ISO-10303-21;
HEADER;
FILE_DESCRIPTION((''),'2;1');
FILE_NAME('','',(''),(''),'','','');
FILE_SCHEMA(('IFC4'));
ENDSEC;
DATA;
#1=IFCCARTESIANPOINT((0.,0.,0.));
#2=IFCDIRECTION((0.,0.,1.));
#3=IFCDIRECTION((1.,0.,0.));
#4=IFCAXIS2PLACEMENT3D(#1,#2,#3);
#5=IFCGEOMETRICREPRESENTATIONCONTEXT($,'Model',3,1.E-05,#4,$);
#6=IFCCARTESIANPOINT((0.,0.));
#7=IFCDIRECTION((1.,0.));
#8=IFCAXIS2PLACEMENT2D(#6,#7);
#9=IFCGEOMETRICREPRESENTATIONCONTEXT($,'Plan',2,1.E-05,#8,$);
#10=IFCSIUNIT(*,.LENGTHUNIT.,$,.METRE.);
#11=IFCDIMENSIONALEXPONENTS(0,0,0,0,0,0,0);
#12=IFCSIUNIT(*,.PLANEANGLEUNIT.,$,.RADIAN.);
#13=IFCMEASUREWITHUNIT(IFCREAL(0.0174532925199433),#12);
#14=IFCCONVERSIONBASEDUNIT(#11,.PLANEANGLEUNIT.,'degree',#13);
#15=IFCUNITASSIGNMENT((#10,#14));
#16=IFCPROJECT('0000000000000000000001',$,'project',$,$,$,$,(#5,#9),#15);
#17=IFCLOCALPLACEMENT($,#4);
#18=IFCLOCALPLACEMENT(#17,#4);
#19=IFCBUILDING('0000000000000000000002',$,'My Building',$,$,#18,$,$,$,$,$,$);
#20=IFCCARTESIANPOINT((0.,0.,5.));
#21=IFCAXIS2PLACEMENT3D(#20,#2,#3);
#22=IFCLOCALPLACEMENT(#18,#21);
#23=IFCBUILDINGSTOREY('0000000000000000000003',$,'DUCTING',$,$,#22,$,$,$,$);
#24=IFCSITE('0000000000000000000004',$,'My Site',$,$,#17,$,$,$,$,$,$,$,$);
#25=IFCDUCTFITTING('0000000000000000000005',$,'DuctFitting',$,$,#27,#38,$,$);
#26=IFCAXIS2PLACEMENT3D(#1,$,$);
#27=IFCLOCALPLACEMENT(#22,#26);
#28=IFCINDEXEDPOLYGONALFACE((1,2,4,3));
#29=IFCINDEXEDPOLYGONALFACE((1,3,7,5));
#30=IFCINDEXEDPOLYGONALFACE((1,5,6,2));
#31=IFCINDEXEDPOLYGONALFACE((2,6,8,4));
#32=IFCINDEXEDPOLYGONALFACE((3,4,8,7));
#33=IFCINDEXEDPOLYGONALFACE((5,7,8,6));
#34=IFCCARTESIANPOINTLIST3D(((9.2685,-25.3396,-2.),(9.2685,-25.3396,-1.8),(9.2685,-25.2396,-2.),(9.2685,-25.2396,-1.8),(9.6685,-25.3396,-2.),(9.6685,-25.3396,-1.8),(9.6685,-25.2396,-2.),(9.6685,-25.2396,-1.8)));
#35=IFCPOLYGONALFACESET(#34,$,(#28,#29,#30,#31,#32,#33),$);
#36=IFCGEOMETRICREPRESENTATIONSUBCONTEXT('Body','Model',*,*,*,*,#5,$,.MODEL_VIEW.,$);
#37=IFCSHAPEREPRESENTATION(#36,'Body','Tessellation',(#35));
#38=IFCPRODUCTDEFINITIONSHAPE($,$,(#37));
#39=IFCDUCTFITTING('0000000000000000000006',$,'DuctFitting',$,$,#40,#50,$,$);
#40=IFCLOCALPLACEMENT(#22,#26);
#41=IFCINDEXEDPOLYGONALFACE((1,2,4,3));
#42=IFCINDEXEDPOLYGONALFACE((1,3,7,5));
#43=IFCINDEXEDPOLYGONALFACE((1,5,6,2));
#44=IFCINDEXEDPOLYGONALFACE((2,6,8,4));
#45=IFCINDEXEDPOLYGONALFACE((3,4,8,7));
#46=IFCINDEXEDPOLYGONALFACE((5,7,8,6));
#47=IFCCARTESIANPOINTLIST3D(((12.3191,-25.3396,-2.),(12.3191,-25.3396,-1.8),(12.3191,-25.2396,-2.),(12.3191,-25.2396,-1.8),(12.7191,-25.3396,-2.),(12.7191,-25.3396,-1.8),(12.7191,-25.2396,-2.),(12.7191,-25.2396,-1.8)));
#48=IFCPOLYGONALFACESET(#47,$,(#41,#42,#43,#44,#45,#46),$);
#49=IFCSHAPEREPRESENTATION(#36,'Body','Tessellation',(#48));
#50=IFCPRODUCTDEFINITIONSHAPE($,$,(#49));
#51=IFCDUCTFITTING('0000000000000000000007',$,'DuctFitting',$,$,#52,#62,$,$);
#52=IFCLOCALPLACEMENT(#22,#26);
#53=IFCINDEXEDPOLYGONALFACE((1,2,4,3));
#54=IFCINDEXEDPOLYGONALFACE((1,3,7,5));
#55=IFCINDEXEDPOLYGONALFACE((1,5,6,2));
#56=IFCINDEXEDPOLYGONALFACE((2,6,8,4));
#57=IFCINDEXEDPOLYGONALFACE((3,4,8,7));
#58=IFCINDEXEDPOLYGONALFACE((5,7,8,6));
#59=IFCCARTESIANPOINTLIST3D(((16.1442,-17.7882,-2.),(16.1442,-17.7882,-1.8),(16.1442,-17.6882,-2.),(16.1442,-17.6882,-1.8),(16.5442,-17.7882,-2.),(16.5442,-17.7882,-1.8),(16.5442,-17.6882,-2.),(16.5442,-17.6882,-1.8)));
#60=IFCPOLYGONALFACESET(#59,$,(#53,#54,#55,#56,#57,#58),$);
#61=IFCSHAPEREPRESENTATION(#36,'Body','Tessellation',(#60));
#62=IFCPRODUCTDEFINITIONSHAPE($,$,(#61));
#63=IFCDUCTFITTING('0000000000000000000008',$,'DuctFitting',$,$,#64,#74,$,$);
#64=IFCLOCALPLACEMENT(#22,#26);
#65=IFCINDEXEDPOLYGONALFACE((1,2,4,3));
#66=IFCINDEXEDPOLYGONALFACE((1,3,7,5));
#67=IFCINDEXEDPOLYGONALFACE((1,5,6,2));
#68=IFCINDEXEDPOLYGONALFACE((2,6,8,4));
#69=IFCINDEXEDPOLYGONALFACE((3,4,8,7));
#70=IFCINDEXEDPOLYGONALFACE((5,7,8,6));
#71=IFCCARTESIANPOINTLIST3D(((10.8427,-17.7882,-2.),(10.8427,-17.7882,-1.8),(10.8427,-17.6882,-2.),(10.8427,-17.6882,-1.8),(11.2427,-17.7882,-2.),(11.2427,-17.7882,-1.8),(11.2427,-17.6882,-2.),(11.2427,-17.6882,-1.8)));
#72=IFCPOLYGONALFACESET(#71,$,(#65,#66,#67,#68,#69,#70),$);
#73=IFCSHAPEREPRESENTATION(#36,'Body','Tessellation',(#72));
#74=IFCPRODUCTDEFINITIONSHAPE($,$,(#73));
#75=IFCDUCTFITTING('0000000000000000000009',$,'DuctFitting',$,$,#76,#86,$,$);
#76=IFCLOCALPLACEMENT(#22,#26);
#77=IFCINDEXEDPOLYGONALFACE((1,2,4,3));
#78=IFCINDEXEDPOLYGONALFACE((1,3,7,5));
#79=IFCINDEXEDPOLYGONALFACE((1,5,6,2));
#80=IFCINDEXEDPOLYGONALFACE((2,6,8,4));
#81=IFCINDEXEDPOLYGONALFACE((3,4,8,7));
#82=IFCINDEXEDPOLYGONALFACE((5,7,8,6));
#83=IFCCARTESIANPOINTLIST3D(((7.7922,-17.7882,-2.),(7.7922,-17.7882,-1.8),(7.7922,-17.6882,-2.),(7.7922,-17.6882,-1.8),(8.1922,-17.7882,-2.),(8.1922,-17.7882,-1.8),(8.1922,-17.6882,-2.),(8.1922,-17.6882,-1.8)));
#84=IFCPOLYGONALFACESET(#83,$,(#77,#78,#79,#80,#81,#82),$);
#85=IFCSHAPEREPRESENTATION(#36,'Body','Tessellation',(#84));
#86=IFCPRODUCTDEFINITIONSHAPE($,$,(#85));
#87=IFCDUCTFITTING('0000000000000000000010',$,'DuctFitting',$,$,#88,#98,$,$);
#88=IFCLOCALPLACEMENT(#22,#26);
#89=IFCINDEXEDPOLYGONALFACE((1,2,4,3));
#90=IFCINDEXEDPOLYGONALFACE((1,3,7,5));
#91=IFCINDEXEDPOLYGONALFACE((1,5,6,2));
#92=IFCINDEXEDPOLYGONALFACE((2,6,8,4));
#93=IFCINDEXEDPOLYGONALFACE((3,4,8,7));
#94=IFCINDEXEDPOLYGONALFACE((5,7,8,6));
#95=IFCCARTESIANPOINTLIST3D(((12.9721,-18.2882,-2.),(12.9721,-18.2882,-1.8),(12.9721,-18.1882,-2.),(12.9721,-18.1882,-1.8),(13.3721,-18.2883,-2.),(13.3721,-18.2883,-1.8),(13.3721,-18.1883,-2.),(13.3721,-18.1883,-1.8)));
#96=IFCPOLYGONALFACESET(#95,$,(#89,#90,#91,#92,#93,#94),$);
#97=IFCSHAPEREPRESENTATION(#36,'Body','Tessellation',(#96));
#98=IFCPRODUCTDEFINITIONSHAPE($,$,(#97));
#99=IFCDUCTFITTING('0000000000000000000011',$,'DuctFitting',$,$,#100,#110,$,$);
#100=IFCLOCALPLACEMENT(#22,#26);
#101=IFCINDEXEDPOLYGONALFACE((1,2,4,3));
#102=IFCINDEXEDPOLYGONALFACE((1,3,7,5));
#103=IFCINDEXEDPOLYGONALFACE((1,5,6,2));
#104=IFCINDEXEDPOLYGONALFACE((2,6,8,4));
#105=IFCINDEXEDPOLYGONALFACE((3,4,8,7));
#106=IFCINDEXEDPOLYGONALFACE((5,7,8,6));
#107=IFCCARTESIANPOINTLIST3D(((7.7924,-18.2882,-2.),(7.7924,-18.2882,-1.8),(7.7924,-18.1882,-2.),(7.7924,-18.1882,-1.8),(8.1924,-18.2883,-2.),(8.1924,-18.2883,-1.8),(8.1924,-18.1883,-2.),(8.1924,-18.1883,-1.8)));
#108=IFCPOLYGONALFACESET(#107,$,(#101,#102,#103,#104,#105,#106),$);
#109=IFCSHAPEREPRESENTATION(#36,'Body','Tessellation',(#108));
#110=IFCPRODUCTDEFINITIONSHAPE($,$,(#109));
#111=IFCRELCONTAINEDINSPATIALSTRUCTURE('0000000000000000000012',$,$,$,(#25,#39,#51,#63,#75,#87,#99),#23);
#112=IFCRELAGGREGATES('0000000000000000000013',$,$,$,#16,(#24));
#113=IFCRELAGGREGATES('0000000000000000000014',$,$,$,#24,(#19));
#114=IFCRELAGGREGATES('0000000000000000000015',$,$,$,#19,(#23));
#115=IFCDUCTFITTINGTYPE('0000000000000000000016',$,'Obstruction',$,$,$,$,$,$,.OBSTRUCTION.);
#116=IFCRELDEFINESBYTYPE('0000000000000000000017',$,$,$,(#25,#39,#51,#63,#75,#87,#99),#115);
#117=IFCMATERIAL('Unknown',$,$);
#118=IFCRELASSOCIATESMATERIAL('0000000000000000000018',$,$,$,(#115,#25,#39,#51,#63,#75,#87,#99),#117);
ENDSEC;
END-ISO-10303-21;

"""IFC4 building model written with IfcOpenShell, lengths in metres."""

from ifc_helpers import new_model, entity, si_unit, converted_unit, frame, origin_with_axes, origin_2d_with_axis, place, context, subcontext, project, spatial, rectangle, extrude, material, material_profile, profile_set, profile_usage, type_object, element, save


model = new_model("IFC4")

# Units and contexts
model_context = context("Model", 3, precision=1e-05, world=origin_with_axes())
plan_context = context("Plan", 2, precision=1e-05, world=origin_2d_with_axis())
body_context = subcontext(model_context, "Body", "Model", "MODEL_VIEW")
ifc_project = project(units=[si_unit("LENGTHUNIT", "METRE"), converted_unit("PLANEANGLEUNIT", "degree", entity("IfcReal", 0.0174532925199433), si_unit("PLANEANGLEUNIT", "RADIAN"), dimensions=[0, 0, 0, 0, 0, 0, 0])], contexts=[model_context, plan_context])

# Site, building, storey
site_placement = place(None, origin_with_axes())
site = spatial("IfcSite", under=ifc_project, at=site_placement, Name="My Site")
building_placement = place(site_placement, origin_with_axes())
building = spatial("IfcBuilding", under=site, at=building_placement, Name="My Building")
storey_placement = place(building_placement, frame((0.0, 0.0, 5.0), z_axis=(0.0, 0.0, 1.0), x_axis=(1.0, 0.0, 0.0)))
storey = spatial("IfcBuildingStorey", under=building, at=storey_placement, Name="DUCTING")

# Shared definitions
ifc_material = material(Name="Unknown")

# Duct fittings
ifc_material_profile_1 = material_profile(ifc_material, rectangle(XDim=0.4, YDim=0.2))
ifc_profile_set_1 = profile_set([ifc_material_profile_1])
duct_fitting_type = type_object("IfcDuctFittingType", Name="Obstruction", PredefinedType="OBSTRUCTION", material=ifc_profile_set_1)
ifc_profile_usage_1 = profile_usage(ifc_profile_set_1, cardinal=5)
duct_fitting_1_placement = place(storey_placement, frame((9.4685, -25.3396, -1.9), z_axis=(0.000001, 1.0, 0.000001), x_axis=(-1.0, 0.000001, 0.0)))
element("IfcDuctFitting", 1, at=duct_fitting_1_placement, inside=storey, type_object=duct_fitting_type, material=ifc_profile_usage_1, Name="DuctFitting", context=body_context, shape_type="SweptSolid", body=[
    extrude(rectangle(XDim=0.4, YDim=0.2), origin_with_axes(), (0.0, 0.0, 1.0), 0.1),
])
ifc_profile_usage_2 = profile_usage(ifc_profile_set_1, cardinal=5)
duct_fitting_2_placement = place(storey_placement, frame((12.5191, -25.3396, -1.9), z_axis=(0.000001, 1.0, 0.000001), x_axis=(-1.0, 0.000001, 0.0)))
element("IfcDuctFitting", 2, at=duct_fitting_2_placement, inside=storey, type_object=duct_fitting_type, material=ifc_profile_usage_2, Name="DuctFitting", context=body_context, shape_type="SweptSolid", body=[
    extrude(rectangle(XDim=0.4, YDim=0.2), origin_with_axes(), (0.0, 0.0, 1.0), 0.1),
])
ifc_profile_usage_3 = profile_usage(ifc_profile_set_1, cardinal=5)
duct_fitting_3_placement = place(storey_placement, frame((16.3442, -17.7882, -1.9), z_axis=(0.0, 1.0, 0.0), x_axis=(-1.0, 0.0, 0.0)))
element("IfcDuctFitting", 3, at=duct_fitting_3_placement, inside=storey, type_object=duct_fitting_type, material=ifc_profile_usage_3, Name="DuctFitting", context=body_context, shape_type="SweptSolid", body=[
    extrude(rectangle(XDim=0.4, YDim=0.2), origin_with_axes(), (0.0, 0.0, 1.0), 0.1),
])
ifc_profile_usage_4 = profile_usage(ifc_profile_set_1, cardinal=5)
duct_fitting_4_placement = place(storey_placement, frame((11.0427, -17.7882, -1.9), z_axis=(0.0, 1.0, 0.0), x_axis=(-1.0, 0.0, 0.0)))
element("IfcDuctFitting", 4, at=duct_fitting_4_placement, inside=storey, type_object=duct_fitting_type, material=ifc_profile_usage_4, Name="DuctFitting", context=body_context, shape_type="SweptSolid", body=[
    extrude(rectangle(XDim=0.4, YDim=0.2), origin_with_axes(), (0.0, 0.0, 1.0), 0.1),
])
ifc_profile_usage_5 = profile_usage(ifc_profile_set_1, cardinal=5)
duct_fitting_5_placement = place(storey_placement, frame((7.9922, -17.7882, -1.9), z_axis=(0.0, 1.0, 0.0), x_axis=(-1.0, 0.0, 0.0)))
element("IfcDuctFitting", 5, at=duct_fitting_5_placement, inside=storey, type_object=duct_fitting_type, material=ifc_profile_usage_5, Name="DuctFitting", context=body_context, shape_type="SweptSolid", body=[
    extrude(rectangle(XDim=0.4, YDim=0.2), origin_with_axes(), (0.0, 0.0, 1.0), 0.1),
])
ifc_profile_usage_6 = profile_usage(ifc_profile_set_1, cardinal=5)
duct_fitting_6_placement = place(storey_placement, frame((13.1721, -18.2883, -1.9), z_axis=(0.000078, 1.0, 0.0), x_axis=(1.0, -0.000078, 0.0)))
element("IfcDuctFitting", 6, at=duct_fitting_6_placement, inside=storey, type_object=duct_fitting_type, material=ifc_profile_usage_6, Name="DuctFitting", context=body_context, shape_type="SweptSolid", body=[
    extrude(rectangle(XDim=0.4, YDim=0.2), origin_with_axes(), (0.0, 0.0, 1.0), 0.1),
])
ifc_profile_usage_7 = profile_usage(ifc_profile_set_1, cardinal=5)
duct_fitting_7_placement = place(storey_placement, frame((7.9924, -18.2883, -1.9), z_axis=(0.000078, 1.0, 0.0), x_axis=(1.0, -0.000078, 0.0)))
element("IfcDuctFitting", 7, at=duct_fitting_7_placement, inside=storey, type_object=duct_fitting_type, material=ifc_profile_usage_7, Name="DuctFitting", context=body_context, shape_type="SweptSolid", body=[
    extrude(rectangle(XDim=0.4, YDim=0.2), origin_with_axes(), (0.0, 0.0, 1.0), 0.1),
])

save(model, "model.ifc")
